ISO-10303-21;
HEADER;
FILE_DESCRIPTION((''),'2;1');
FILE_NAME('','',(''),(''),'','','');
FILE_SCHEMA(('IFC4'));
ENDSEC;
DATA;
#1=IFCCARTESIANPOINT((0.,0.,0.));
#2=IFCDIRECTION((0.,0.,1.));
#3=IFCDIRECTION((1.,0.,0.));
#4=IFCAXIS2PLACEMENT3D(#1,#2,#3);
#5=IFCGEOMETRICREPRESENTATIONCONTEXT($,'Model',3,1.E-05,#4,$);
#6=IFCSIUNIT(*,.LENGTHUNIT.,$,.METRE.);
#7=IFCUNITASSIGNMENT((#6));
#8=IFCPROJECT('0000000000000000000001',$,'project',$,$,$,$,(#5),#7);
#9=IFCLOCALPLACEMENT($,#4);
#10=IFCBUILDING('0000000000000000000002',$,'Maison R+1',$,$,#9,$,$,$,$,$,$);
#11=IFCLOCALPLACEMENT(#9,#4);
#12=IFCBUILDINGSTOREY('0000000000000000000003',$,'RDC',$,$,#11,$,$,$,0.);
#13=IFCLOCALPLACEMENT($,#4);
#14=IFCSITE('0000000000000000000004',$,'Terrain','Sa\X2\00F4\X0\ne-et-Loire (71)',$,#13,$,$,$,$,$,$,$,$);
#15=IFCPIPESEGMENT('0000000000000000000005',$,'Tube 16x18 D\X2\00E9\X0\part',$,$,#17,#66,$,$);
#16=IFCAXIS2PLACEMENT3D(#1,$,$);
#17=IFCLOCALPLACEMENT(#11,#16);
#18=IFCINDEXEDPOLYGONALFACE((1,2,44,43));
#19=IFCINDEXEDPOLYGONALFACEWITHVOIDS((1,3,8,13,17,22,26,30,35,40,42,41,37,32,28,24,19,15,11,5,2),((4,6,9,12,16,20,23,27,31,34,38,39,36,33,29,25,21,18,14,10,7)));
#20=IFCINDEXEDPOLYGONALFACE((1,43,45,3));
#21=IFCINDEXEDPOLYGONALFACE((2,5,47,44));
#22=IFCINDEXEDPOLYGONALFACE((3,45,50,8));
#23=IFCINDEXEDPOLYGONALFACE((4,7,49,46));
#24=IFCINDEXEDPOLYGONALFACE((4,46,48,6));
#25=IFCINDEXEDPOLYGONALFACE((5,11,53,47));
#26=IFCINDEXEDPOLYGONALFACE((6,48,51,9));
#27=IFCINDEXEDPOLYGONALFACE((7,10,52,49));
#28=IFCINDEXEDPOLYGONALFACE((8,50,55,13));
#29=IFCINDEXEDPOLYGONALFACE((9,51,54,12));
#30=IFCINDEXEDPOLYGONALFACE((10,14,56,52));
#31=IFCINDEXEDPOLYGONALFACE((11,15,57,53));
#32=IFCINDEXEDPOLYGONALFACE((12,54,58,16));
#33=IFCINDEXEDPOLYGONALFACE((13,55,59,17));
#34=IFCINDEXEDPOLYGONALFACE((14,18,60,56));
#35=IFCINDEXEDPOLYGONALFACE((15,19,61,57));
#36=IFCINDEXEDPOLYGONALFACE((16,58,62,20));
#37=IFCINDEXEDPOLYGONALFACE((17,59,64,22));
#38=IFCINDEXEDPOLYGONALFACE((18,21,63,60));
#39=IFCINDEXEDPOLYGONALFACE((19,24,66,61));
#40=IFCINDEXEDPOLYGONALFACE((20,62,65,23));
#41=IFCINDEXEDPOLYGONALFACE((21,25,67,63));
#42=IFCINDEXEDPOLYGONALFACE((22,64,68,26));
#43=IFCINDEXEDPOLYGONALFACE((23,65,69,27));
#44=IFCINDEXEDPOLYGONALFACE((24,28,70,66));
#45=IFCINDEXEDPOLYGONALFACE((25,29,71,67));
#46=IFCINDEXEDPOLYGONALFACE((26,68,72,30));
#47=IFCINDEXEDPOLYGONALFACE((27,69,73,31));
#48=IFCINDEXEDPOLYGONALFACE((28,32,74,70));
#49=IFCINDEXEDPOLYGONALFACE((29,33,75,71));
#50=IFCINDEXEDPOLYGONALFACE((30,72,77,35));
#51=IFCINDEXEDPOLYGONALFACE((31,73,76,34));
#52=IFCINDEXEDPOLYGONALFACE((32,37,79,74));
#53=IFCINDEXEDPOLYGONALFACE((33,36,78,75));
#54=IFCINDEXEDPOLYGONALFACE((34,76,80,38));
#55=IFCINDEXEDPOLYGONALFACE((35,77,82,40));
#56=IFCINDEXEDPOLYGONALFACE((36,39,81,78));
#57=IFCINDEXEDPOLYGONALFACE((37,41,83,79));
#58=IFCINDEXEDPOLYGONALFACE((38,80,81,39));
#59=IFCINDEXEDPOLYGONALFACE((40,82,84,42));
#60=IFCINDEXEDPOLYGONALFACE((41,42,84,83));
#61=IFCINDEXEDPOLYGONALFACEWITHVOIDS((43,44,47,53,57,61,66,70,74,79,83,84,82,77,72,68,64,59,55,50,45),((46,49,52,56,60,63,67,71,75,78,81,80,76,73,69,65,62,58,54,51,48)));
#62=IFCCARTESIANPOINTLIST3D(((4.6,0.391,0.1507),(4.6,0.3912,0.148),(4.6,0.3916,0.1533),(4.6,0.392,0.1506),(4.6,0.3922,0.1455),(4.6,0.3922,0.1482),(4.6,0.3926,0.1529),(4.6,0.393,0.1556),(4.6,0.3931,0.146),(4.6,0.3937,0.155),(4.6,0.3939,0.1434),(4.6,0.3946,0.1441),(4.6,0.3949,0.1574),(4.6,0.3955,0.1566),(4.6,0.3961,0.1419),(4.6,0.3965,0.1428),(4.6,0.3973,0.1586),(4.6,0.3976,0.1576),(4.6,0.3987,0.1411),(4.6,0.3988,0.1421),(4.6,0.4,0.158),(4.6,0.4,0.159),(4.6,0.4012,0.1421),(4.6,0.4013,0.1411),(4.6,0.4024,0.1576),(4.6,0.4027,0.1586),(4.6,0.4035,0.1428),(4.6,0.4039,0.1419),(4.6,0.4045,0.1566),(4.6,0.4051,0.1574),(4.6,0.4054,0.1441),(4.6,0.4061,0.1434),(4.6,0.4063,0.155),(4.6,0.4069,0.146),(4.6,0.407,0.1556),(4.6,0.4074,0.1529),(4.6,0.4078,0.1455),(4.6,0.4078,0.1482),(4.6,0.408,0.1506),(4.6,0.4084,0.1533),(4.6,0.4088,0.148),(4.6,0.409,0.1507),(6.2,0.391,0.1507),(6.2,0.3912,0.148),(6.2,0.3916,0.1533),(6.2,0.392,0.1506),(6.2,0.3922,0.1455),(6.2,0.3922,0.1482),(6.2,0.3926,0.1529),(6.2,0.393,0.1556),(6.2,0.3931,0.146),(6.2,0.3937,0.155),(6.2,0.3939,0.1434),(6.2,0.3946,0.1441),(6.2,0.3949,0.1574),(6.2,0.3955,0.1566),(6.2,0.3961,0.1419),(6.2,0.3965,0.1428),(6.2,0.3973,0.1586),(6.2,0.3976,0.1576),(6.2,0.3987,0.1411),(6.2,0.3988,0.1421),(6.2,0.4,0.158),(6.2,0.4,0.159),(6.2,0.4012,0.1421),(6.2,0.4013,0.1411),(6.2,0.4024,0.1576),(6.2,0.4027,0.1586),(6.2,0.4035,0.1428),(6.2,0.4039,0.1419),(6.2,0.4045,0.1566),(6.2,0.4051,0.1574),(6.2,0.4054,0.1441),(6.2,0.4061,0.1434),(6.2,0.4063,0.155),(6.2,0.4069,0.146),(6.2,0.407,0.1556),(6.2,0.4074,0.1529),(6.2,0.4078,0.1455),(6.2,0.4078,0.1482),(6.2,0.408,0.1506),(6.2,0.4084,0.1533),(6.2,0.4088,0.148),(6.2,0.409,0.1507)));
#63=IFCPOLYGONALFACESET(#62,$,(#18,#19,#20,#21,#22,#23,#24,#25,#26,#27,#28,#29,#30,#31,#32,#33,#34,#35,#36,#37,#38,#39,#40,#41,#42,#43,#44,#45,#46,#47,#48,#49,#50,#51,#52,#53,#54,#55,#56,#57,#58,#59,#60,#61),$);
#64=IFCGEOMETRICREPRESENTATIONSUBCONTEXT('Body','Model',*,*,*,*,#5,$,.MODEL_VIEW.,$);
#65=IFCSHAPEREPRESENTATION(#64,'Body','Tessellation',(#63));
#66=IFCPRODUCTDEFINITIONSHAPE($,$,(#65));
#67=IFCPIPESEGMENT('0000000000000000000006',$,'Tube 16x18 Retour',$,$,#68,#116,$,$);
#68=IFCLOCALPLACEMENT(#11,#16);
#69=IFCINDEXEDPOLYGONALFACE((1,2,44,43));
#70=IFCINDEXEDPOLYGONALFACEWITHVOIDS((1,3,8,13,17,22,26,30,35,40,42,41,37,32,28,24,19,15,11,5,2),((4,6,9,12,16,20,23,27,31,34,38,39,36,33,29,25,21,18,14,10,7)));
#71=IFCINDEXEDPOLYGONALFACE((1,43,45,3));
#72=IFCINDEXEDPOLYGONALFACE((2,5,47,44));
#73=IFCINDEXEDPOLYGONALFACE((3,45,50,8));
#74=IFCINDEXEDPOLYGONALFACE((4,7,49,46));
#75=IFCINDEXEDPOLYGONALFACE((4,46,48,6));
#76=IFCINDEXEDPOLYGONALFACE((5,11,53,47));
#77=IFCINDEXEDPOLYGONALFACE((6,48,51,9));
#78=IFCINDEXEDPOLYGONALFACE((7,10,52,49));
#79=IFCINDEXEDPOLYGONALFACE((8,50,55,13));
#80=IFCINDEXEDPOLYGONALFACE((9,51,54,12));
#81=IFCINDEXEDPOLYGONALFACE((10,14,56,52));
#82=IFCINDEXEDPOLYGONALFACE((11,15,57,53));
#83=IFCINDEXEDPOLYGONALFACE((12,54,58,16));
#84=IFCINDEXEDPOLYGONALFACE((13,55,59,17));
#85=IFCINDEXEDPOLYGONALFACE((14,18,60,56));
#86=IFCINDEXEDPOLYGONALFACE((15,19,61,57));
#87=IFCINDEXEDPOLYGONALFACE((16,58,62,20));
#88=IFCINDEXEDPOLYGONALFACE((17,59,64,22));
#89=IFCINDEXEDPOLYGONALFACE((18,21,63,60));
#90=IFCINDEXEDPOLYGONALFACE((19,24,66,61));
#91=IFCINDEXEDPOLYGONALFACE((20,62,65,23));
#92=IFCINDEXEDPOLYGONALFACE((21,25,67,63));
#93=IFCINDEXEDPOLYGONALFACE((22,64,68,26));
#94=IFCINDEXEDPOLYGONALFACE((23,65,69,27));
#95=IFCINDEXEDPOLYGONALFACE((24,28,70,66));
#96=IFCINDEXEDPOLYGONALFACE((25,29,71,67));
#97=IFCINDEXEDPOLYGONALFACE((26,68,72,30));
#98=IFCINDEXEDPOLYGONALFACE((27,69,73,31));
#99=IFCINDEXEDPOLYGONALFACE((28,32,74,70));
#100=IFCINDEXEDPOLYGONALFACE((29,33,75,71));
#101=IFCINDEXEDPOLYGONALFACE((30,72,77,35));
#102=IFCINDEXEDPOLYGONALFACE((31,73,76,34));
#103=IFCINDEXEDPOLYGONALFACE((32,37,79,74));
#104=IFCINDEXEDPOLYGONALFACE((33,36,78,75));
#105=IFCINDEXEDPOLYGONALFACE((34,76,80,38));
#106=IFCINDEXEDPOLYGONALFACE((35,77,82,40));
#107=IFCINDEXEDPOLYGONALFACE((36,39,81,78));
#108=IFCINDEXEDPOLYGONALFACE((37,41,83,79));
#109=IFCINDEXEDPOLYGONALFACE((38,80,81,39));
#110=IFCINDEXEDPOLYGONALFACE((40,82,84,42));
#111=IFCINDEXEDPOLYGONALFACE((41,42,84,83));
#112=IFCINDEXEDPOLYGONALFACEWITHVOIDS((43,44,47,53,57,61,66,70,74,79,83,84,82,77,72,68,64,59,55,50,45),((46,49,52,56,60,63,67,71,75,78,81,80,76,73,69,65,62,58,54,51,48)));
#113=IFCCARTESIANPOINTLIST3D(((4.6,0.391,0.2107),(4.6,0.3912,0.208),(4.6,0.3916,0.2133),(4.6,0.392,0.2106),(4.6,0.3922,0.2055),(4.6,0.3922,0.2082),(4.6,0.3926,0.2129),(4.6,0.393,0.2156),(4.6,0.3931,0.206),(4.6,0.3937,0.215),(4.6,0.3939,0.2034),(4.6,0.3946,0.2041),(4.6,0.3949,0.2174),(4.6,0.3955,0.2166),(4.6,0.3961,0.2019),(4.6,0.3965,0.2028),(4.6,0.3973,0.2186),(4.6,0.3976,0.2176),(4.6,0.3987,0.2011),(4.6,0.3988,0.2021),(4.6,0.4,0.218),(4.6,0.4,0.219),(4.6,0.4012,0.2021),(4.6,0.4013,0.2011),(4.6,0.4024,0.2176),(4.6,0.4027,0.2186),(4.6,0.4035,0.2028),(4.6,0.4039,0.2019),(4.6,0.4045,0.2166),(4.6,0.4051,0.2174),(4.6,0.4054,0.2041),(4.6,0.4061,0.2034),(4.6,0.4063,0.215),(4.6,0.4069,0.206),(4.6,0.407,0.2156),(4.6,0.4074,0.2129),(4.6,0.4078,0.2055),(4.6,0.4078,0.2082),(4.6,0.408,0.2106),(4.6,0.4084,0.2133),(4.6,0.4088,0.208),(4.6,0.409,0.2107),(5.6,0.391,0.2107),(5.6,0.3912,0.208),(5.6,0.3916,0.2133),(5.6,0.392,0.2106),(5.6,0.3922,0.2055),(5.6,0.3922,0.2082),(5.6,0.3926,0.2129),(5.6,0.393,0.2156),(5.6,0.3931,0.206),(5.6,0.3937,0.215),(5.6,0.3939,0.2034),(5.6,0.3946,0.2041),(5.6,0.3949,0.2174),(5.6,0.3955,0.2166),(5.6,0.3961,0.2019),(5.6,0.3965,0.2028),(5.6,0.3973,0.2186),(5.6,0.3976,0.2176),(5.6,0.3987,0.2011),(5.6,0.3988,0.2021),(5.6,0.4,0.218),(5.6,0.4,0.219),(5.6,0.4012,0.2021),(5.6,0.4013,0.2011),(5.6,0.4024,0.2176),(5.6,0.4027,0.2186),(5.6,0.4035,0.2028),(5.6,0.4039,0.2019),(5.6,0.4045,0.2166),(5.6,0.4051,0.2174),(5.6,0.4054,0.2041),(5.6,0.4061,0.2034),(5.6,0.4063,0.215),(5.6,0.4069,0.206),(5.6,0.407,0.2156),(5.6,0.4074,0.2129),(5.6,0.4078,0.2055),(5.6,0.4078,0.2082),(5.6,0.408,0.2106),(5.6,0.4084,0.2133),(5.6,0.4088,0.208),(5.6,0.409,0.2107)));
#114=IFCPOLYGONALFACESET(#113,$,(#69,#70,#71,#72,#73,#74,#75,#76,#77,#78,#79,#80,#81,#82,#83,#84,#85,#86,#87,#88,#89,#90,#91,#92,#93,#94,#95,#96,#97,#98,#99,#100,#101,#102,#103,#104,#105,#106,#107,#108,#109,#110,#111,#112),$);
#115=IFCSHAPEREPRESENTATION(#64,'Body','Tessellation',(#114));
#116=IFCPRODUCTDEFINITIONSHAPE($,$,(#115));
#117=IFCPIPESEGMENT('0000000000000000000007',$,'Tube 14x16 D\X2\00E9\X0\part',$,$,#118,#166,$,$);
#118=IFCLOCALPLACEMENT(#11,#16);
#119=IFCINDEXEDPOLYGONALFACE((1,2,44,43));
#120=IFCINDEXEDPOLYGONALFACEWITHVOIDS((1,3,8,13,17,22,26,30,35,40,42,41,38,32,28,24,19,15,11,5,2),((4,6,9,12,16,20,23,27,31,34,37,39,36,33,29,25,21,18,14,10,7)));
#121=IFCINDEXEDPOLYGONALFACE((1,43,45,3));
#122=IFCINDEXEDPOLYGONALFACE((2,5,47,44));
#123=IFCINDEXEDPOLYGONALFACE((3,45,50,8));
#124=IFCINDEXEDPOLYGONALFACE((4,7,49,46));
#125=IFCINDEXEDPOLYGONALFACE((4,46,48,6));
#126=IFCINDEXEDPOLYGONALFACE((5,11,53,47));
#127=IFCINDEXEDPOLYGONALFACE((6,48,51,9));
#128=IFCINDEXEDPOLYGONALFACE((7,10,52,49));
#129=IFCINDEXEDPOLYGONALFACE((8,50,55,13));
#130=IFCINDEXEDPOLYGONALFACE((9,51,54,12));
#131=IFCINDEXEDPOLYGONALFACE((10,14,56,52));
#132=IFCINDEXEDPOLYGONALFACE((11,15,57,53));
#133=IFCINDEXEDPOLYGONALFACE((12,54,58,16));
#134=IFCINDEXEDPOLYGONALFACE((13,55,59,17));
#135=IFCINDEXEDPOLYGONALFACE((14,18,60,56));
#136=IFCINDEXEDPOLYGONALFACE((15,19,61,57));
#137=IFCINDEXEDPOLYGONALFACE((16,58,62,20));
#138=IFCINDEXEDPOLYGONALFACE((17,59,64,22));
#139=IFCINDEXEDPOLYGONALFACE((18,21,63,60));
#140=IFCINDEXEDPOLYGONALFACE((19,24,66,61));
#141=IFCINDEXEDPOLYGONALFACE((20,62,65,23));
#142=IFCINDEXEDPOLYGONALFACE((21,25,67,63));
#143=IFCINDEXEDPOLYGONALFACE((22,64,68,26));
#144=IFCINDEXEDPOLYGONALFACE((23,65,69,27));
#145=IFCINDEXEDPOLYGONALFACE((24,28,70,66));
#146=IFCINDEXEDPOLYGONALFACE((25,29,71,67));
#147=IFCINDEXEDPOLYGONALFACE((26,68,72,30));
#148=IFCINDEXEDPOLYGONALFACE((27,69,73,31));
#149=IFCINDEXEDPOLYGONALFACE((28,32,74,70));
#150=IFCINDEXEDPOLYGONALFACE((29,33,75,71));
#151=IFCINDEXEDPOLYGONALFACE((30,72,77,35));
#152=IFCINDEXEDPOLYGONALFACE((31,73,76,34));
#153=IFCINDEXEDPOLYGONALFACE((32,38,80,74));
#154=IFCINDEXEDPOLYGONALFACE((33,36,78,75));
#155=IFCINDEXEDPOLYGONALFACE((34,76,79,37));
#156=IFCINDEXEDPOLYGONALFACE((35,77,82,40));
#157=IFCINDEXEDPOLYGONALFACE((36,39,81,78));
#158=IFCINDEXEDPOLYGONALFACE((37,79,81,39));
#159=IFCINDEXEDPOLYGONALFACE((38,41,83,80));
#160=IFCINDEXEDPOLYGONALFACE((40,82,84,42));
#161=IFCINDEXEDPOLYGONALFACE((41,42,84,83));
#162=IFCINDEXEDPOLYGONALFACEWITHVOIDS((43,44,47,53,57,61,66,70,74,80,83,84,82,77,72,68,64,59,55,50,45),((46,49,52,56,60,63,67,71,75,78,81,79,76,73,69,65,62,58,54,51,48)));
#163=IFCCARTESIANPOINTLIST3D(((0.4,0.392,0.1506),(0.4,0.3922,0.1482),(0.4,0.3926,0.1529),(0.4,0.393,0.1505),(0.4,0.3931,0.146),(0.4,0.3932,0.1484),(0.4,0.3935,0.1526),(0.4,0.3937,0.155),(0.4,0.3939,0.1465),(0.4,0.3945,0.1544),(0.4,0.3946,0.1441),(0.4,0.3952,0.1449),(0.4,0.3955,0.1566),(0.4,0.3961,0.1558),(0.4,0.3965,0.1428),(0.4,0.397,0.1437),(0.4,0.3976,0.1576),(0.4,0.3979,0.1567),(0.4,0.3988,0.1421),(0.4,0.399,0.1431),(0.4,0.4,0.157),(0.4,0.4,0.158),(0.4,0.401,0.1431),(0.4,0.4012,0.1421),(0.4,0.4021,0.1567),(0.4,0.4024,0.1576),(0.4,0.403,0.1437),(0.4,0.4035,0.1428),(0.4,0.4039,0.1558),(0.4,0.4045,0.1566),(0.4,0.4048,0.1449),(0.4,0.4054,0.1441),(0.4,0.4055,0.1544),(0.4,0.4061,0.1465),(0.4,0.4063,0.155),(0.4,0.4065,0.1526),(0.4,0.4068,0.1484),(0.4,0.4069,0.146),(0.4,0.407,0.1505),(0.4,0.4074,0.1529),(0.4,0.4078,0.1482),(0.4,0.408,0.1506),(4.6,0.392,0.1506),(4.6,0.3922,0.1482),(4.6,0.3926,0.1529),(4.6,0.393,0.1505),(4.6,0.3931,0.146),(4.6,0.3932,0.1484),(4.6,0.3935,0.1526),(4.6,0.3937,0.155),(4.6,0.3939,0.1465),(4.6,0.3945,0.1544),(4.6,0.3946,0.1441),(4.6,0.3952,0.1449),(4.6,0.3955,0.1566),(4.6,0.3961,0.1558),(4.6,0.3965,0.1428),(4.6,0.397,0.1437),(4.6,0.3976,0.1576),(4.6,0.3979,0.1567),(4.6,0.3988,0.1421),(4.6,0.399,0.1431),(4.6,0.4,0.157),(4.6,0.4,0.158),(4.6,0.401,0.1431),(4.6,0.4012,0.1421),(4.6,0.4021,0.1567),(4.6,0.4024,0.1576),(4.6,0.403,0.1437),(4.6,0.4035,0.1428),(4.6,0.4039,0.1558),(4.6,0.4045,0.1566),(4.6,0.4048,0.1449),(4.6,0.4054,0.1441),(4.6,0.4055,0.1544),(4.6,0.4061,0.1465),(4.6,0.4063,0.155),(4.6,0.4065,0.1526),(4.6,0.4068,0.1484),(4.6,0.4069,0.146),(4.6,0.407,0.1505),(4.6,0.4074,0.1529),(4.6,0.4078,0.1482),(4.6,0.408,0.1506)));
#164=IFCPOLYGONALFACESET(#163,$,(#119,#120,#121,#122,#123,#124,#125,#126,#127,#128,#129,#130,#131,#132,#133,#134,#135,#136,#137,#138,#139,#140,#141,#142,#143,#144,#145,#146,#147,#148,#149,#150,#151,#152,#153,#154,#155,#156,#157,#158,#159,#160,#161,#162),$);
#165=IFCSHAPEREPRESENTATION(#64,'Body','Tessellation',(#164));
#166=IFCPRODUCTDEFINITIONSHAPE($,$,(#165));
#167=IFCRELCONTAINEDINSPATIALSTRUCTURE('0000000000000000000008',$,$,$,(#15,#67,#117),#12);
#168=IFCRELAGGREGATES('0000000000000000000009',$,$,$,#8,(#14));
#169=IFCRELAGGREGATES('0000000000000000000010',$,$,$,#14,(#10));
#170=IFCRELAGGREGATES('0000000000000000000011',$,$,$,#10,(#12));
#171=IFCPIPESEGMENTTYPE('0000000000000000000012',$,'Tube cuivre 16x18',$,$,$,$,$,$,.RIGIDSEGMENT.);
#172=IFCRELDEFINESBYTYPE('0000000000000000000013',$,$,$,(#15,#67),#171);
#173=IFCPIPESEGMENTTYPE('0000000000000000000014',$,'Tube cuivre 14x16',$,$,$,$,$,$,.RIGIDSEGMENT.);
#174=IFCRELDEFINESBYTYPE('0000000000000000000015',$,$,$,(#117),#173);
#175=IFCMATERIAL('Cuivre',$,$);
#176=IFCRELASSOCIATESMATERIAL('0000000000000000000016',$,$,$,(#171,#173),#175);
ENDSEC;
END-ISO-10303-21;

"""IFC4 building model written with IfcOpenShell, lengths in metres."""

from ifc_helpers import new_model, si_unit, frame, origin_with_axes, place, context, subcontext, project, spatial, hollow_circle, extrude, material, type_object, element, save


model = new_model("IFC4")

# Units and contexts
model_context = context("Model", 3, precision=1e-05, world=origin_with_axes())
body_context = subcontext(model_context, "Body", "Model", "MODEL_VIEW")
ifc_project = project(units=[si_unit("LENGTHUNIT", "METRE")], contexts=[model_context])

# Site, building, storey
site_placement = place(None, origin_with_axes())
site = spatial("IfcSite", under=ifc_project, at=site_placement, Name="Terrain", Description="Saône-et-Loire (71)")
building_placement = place(None, origin_with_axes())
building = spatial("IfcBuilding", under=site, at=building_placement, Name="Maison R+1")
storey_placement = place(building_placement, origin_with_axes())
storey = spatial("IfcBuildingStorey", under=building, at=storey_placement, Name="RDC", Elevation=0.0)

# Pipe segments
ifc_material_1 = material(Name="Cuivre")
pipe_segment_type_1 = type_object("IfcPipeSegmentType", Name="Tube cuivre 16x18", PredefinedType="RIGIDSEGMENT", material=ifc_material_1)
pipe_segment_1_placement = place(storey_placement, frame((6.2, 0.4, 0.15), z_axis=(-1.0, 0.0, 0.0), x_axis=(0.0, 0.0, 1.0)))
element("IfcPipeSegment", 1, at=pipe_segment_1_placement, inside=storey, type_object=pipe_segment_type_1, Name="Tube 16x18 Départ", context=body_context, shape_type="SweptSolid", body=[
    extrude(hollow_circle(Radius=0.009, WallThickness=0.001), origin_with_axes(), (0.0, 0.0, 1.0), 1.6),
])
pipe_segment_2_placement = place(storey_placement, frame((5.6, 0.4, 0.21), z_axis=(-1.0, 0.0, 0.0), x_axis=(0.0, 0.0, 1.0)))
element("IfcPipeSegment", 2, at=pipe_segment_2_placement, inside=storey, type_object=pipe_segment_type_1, Name="Tube 16x18 Retour", context=body_context, shape_type="SweptSolid", body=[
    extrude(hollow_circle(Radius=0.009, WallThickness=0.001), origin_with_axes(), (0.0, 0.0, 1.0), 1.0),
])
pipe_segment_type_2 = type_object("IfcPipeSegmentType", Name="Tube cuivre 14x16", PredefinedType="RIGIDSEGMENT", material=ifc_material_1)
for number, where, z_axis, x_axis, name in (
    (3, (4.6, 0.4, 0.15), (-1.0, 0.0, 0.0), (0.0, 0.0, 1.0), "Tube 14x16 Départ"),
):
    element("IfcPipeSegment", number, at=place(storey_placement, frame(where, z_axis=z_axis, x_axis=x_axis)), inside=storey, type_object=pipe_segment_type_2, Name=name, context=body_context, shape_type="SweptSolid", body=[
        extrude(hollow_circle(Radius=0.008, WallThickness=0.001), origin_with_axes(), (0.0, 0.0, 1.0), 4.2),
    ])

save(model, "model.ifc")
